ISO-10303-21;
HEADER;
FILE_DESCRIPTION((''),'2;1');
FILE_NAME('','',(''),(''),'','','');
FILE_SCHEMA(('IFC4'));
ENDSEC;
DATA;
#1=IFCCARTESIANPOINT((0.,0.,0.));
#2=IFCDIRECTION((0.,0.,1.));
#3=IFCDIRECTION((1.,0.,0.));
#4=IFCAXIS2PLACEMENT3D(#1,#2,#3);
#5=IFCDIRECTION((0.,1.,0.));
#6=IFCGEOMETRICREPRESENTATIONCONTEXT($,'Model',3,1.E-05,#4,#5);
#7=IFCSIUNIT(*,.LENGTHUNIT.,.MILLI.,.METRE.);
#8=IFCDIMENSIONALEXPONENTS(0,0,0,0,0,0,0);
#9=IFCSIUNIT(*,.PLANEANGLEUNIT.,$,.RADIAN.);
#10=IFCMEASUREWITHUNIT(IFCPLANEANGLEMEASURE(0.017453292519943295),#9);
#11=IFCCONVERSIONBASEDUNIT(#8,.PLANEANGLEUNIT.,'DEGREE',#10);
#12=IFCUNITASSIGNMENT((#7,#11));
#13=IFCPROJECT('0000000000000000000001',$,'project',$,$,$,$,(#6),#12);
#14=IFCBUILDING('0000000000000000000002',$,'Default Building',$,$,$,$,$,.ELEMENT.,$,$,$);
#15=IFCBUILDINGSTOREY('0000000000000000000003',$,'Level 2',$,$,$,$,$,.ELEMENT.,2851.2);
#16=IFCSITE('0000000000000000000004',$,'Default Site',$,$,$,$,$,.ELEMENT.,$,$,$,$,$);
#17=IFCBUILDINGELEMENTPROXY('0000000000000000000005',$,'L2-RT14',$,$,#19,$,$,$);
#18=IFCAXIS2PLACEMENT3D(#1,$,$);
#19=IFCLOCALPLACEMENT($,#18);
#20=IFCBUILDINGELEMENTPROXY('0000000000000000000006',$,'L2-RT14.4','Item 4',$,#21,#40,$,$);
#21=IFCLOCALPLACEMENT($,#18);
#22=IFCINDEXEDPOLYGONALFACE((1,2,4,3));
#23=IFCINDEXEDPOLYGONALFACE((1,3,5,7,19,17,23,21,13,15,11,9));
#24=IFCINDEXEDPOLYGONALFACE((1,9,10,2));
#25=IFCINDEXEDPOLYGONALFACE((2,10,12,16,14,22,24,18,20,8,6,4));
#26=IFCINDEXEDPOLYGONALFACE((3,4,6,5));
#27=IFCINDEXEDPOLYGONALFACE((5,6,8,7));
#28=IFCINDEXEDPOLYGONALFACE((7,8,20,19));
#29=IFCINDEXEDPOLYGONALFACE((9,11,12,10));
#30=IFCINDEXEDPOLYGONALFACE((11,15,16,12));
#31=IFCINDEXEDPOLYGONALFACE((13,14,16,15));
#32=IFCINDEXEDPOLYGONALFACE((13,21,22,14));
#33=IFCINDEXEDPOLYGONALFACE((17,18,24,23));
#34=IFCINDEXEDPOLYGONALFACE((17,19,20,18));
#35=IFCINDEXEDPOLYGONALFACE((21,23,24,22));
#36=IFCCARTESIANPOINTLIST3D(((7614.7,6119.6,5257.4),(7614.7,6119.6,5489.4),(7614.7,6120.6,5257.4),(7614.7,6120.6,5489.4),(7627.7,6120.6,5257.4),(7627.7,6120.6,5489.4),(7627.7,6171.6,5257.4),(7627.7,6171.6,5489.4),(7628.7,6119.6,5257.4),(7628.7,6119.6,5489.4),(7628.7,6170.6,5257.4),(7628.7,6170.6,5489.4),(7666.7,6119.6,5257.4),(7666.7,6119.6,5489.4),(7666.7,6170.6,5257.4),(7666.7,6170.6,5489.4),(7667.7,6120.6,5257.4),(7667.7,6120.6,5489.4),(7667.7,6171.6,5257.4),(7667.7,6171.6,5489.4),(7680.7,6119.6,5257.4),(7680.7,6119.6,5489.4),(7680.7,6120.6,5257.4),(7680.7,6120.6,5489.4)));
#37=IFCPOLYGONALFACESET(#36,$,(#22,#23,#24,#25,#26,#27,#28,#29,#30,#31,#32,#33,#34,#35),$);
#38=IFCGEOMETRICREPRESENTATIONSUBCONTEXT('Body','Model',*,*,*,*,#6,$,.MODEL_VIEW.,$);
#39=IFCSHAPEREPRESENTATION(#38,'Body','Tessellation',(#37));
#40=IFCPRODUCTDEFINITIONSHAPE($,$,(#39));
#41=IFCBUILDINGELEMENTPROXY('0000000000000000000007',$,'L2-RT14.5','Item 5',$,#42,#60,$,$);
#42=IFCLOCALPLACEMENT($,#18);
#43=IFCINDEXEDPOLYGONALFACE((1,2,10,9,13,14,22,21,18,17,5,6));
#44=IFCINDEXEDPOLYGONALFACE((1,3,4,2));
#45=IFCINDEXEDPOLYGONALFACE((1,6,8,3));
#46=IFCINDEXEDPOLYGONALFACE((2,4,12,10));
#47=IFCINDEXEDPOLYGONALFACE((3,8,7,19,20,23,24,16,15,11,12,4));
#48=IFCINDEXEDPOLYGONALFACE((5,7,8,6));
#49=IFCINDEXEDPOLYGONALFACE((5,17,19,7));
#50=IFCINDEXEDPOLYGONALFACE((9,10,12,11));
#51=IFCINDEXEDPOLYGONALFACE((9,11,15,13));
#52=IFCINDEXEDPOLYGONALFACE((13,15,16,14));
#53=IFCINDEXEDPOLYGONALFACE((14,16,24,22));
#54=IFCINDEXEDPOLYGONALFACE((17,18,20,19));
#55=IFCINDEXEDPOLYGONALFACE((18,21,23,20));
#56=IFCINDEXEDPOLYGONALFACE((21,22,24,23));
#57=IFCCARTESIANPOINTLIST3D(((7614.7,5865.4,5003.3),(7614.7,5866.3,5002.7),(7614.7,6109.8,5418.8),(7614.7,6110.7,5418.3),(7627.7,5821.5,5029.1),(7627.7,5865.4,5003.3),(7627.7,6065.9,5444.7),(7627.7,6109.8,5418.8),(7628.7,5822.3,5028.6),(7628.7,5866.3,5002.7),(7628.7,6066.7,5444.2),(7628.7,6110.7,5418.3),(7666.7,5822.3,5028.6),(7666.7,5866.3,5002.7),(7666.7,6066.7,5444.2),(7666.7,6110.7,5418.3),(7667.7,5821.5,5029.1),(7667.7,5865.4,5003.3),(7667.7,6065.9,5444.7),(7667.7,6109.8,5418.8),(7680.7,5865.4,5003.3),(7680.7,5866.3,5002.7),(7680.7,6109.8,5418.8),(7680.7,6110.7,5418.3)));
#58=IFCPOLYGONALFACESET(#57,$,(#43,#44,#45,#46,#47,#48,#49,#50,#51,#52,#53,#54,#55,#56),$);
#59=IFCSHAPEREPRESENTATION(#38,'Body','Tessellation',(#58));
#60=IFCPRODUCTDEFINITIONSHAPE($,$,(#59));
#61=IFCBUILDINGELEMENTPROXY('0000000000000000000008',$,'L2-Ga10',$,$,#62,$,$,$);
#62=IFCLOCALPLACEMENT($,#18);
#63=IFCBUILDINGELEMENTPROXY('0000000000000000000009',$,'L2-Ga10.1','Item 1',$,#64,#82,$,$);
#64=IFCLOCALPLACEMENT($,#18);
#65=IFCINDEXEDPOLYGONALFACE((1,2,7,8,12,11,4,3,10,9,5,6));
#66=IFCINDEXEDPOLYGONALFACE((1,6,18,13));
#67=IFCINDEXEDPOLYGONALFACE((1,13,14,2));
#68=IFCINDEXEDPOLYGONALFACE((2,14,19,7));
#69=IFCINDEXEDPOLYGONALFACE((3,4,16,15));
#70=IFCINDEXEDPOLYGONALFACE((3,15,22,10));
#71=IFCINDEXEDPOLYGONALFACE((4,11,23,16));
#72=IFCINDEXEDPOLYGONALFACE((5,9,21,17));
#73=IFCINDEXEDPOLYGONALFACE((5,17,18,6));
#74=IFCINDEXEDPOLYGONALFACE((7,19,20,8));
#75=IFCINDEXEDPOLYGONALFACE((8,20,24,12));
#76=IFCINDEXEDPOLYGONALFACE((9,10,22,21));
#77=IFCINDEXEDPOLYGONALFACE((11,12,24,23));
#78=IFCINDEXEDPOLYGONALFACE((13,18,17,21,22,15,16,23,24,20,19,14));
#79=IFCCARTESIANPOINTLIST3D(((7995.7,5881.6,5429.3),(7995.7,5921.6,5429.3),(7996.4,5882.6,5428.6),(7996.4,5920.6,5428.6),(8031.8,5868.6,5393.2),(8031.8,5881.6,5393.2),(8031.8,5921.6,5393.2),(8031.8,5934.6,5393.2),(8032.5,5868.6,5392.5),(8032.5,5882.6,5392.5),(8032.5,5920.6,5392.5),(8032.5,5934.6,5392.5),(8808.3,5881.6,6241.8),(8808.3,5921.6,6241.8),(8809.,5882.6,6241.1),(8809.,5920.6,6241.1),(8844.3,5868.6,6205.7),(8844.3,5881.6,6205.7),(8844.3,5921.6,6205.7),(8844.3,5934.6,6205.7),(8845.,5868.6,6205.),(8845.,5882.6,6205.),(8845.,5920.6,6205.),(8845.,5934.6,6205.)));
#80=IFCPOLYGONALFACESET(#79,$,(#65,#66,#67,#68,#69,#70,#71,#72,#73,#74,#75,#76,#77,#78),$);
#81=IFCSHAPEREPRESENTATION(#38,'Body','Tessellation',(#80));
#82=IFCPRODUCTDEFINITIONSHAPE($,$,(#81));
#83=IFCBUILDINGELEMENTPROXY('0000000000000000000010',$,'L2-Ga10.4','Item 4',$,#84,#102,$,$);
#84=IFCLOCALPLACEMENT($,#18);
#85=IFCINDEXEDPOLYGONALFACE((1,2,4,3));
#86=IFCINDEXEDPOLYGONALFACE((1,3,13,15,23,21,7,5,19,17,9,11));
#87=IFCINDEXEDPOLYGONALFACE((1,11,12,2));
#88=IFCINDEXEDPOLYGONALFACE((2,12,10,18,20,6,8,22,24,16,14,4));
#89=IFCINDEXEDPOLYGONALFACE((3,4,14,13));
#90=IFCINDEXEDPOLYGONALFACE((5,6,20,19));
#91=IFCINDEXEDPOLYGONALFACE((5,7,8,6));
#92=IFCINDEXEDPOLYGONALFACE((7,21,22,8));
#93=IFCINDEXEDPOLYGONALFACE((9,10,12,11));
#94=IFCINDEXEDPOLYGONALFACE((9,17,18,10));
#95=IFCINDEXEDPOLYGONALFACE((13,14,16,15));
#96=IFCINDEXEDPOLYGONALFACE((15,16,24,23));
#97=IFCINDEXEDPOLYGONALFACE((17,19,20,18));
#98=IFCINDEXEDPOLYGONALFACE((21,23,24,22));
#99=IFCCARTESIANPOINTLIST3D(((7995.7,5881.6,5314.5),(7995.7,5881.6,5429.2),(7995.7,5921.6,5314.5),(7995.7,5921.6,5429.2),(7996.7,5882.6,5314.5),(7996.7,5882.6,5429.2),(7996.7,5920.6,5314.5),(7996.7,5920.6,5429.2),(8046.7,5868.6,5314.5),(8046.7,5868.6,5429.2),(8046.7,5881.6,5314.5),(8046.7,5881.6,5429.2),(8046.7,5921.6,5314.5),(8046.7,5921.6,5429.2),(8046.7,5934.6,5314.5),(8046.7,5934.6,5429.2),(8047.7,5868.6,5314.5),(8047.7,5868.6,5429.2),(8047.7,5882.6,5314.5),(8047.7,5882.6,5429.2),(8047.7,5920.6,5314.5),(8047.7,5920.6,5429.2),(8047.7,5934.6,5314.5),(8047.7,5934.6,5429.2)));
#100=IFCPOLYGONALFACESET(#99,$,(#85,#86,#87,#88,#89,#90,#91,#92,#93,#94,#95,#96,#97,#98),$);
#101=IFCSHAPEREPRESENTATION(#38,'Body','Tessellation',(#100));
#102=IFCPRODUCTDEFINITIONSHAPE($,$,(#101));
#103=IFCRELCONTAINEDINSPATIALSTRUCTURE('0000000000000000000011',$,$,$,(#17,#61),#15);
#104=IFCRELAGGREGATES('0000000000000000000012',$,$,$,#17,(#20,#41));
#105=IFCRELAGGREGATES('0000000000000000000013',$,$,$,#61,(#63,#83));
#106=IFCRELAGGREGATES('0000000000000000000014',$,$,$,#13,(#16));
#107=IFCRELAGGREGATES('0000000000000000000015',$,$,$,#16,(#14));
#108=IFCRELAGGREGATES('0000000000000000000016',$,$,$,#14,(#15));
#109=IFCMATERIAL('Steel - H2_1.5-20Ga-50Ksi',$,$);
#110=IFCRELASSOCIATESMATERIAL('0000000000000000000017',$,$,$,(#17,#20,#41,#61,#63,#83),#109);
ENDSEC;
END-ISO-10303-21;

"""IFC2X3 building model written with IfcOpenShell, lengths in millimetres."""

from ifc_helpers import new_model, entity, si_unit, converted_unit, direction, frame, origin, origin_with_axes, place, context, subcontext, project, spatial, polyline, outline, extrude, material, element, aggregate, save


model = new_model("IFC2X3")

# Units and contexts
model_context = context("Model", 3, precision=1e-05, world=origin_with_axes(), true_north=direction((0.0, 1.0, 0.0)))
body_context = subcontext(model_context, "Body", "Model", "MODEL_VIEW")
ifc_project = project(units=[si_unit("LENGTHUNIT", "METRE", prefix="MILLI"), converted_unit("PLANEANGLEUNIT", "DEGREE", entity("IfcPlaneAngleMeasure", 0.017453292519943295), si_unit("PLANEANGLEUNIT", "RADIAN"), dimensions=[0, 0, 0, 0, 0, 0, 0])], contexts=[model_context])

# Site, building, storey
site = spatial("IfcSite", under=ifc_project, Name="Default Site", CompositionType="ELEMENT")
building = spatial("IfcBuilding", under=site, Name="Default Building", CompositionType="ELEMENT")
storey = spatial("IfcBuildingStorey", under=building, Name="Level 2", CompositionType="ELEMENT", Elevation=2851.2)

# Building element proxies
ifc_material = material(Name="Steel - H2_1.5-20Ga-50Ksi")
proxy_1 = element("IfcBuildingElementProxy", 1, inside=storey, material=ifc_material, Name="L2-RT14")
proxy_2_placement = place(None, frame((7614.7, 6119.6, 5257.4), z_axis=(0.0, 0.0, 1.0), x_axis=(40.0, 0.0, 0.0)))
proxy_2 = element("IfcBuildingElementProxy", 2, at=proxy_2_placement, material=ifc_material, Name="L2-RT14.4", Description="Item 4", context=body_context, shape_type="SweptSolid", body=[
    extrude(outline(polyline([(0.0, 0.0), (14.0, 0.0), (14.0, 51.0), (52.0, 51.0), (52.0, 0.0), (66.0, 0.0), (66.0, 1.0), (53.0, 1.0), (53.0, 52.0), (13.0, 52.0), (13.0, 1.0), (0.0, 1.0), (0.0, 0.0)])), origin(), (0.0, 0.0, 1.0), 232.0),
])
proxy_3_placement = place(None, frame((7614.7, 6110.7, 5418.3), z_axis=(0.0, -0.507, -0.862), x_axis=(40.0, 0.0, 0.0)))
proxy_3 = element("IfcBuildingElementProxy", 3, at=proxy_3_placement, material=ifc_material, Name="L2-RT14.5", Description="Item 5", context=body_context, shape_type="SweptSolid", body=[
    extrude(outline(polyline([(0.0, 0.0), (14.0, 0.0), (14.0, 51.0), (52.0, 51.0), (52.0, 0.0), (66.0, 0.0), (66.0, 1.0), (53.0, 1.0), (53.0, 52.0), (13.0, 52.0), (13.0, 1.0), (0.0, 1.0), (0.0, 0.0)])), origin(), (0.0, 0.0, 1.0), 482.1),
])
aggregate(proxy_1, [proxy_2, proxy_3])
proxy_4 = element("IfcBuildingElementProxy", 4, inside=storey, material=ifc_material, Name="L2-Ga10")
proxy_5_placement = place(None, frame((8032.5, 5868.6, 5392.5), z_axis=(0.707, 0.0, 0.707), x_axis=(0.0, 40.0, 0.0)))
proxy_5 = element("IfcBuildingElementProxy", 5, at=proxy_5_placement, material=ifc_material, Name="L2-Ga10.1", Description="Item 1", context=body_context, shape_type="SweptSolid", body=[
    extrude(outline(polyline([(0.0, 0.0), (14.0, 0.0), (14.0, 51.0), (52.0, 51.0), (52.0, 0.0), (66.0, 0.0), (66.0, 1.0), (53.0, 1.0), (53.0, 52.0), (13.0, 52.0), (13.0, 1.0), (0.0, 1.0), (0.0, 0.0)])), origin(), (0.0, 0.0, 1.0), 1149.1),
])
proxy_6_placement = place(None, frame((8047.7, 5868.6, 5314.5), z_axis=(0.0, 0.0, 1.0), x_axis=(0.0, 40.0, 0.0)))
proxy_6 = element("IfcBuildingElementProxy", 6, at=proxy_6_placement, material=ifc_material, Name="L2-Ga10.4", Description="Item 4", context=body_context, shape_type="SweptSolid", body=[
    extrude(outline(polyline([(0.0, 0.0), (14.0, 0.0), (14.0, 51.0), (52.0, 51.0), (52.0, 0.0), (66.0, 0.0), (66.0, 1.0), (53.0, 1.0), (53.0, 52.0), (13.0, 52.0), (13.0, 1.0), (0.0, 1.0), (0.0, 0.0)])), origin(), (0.0, 0.0, 1.0), 114.7),
])
aggregate(proxy_4, [proxy_5, proxy_6])

save(model, "model.ifc")
